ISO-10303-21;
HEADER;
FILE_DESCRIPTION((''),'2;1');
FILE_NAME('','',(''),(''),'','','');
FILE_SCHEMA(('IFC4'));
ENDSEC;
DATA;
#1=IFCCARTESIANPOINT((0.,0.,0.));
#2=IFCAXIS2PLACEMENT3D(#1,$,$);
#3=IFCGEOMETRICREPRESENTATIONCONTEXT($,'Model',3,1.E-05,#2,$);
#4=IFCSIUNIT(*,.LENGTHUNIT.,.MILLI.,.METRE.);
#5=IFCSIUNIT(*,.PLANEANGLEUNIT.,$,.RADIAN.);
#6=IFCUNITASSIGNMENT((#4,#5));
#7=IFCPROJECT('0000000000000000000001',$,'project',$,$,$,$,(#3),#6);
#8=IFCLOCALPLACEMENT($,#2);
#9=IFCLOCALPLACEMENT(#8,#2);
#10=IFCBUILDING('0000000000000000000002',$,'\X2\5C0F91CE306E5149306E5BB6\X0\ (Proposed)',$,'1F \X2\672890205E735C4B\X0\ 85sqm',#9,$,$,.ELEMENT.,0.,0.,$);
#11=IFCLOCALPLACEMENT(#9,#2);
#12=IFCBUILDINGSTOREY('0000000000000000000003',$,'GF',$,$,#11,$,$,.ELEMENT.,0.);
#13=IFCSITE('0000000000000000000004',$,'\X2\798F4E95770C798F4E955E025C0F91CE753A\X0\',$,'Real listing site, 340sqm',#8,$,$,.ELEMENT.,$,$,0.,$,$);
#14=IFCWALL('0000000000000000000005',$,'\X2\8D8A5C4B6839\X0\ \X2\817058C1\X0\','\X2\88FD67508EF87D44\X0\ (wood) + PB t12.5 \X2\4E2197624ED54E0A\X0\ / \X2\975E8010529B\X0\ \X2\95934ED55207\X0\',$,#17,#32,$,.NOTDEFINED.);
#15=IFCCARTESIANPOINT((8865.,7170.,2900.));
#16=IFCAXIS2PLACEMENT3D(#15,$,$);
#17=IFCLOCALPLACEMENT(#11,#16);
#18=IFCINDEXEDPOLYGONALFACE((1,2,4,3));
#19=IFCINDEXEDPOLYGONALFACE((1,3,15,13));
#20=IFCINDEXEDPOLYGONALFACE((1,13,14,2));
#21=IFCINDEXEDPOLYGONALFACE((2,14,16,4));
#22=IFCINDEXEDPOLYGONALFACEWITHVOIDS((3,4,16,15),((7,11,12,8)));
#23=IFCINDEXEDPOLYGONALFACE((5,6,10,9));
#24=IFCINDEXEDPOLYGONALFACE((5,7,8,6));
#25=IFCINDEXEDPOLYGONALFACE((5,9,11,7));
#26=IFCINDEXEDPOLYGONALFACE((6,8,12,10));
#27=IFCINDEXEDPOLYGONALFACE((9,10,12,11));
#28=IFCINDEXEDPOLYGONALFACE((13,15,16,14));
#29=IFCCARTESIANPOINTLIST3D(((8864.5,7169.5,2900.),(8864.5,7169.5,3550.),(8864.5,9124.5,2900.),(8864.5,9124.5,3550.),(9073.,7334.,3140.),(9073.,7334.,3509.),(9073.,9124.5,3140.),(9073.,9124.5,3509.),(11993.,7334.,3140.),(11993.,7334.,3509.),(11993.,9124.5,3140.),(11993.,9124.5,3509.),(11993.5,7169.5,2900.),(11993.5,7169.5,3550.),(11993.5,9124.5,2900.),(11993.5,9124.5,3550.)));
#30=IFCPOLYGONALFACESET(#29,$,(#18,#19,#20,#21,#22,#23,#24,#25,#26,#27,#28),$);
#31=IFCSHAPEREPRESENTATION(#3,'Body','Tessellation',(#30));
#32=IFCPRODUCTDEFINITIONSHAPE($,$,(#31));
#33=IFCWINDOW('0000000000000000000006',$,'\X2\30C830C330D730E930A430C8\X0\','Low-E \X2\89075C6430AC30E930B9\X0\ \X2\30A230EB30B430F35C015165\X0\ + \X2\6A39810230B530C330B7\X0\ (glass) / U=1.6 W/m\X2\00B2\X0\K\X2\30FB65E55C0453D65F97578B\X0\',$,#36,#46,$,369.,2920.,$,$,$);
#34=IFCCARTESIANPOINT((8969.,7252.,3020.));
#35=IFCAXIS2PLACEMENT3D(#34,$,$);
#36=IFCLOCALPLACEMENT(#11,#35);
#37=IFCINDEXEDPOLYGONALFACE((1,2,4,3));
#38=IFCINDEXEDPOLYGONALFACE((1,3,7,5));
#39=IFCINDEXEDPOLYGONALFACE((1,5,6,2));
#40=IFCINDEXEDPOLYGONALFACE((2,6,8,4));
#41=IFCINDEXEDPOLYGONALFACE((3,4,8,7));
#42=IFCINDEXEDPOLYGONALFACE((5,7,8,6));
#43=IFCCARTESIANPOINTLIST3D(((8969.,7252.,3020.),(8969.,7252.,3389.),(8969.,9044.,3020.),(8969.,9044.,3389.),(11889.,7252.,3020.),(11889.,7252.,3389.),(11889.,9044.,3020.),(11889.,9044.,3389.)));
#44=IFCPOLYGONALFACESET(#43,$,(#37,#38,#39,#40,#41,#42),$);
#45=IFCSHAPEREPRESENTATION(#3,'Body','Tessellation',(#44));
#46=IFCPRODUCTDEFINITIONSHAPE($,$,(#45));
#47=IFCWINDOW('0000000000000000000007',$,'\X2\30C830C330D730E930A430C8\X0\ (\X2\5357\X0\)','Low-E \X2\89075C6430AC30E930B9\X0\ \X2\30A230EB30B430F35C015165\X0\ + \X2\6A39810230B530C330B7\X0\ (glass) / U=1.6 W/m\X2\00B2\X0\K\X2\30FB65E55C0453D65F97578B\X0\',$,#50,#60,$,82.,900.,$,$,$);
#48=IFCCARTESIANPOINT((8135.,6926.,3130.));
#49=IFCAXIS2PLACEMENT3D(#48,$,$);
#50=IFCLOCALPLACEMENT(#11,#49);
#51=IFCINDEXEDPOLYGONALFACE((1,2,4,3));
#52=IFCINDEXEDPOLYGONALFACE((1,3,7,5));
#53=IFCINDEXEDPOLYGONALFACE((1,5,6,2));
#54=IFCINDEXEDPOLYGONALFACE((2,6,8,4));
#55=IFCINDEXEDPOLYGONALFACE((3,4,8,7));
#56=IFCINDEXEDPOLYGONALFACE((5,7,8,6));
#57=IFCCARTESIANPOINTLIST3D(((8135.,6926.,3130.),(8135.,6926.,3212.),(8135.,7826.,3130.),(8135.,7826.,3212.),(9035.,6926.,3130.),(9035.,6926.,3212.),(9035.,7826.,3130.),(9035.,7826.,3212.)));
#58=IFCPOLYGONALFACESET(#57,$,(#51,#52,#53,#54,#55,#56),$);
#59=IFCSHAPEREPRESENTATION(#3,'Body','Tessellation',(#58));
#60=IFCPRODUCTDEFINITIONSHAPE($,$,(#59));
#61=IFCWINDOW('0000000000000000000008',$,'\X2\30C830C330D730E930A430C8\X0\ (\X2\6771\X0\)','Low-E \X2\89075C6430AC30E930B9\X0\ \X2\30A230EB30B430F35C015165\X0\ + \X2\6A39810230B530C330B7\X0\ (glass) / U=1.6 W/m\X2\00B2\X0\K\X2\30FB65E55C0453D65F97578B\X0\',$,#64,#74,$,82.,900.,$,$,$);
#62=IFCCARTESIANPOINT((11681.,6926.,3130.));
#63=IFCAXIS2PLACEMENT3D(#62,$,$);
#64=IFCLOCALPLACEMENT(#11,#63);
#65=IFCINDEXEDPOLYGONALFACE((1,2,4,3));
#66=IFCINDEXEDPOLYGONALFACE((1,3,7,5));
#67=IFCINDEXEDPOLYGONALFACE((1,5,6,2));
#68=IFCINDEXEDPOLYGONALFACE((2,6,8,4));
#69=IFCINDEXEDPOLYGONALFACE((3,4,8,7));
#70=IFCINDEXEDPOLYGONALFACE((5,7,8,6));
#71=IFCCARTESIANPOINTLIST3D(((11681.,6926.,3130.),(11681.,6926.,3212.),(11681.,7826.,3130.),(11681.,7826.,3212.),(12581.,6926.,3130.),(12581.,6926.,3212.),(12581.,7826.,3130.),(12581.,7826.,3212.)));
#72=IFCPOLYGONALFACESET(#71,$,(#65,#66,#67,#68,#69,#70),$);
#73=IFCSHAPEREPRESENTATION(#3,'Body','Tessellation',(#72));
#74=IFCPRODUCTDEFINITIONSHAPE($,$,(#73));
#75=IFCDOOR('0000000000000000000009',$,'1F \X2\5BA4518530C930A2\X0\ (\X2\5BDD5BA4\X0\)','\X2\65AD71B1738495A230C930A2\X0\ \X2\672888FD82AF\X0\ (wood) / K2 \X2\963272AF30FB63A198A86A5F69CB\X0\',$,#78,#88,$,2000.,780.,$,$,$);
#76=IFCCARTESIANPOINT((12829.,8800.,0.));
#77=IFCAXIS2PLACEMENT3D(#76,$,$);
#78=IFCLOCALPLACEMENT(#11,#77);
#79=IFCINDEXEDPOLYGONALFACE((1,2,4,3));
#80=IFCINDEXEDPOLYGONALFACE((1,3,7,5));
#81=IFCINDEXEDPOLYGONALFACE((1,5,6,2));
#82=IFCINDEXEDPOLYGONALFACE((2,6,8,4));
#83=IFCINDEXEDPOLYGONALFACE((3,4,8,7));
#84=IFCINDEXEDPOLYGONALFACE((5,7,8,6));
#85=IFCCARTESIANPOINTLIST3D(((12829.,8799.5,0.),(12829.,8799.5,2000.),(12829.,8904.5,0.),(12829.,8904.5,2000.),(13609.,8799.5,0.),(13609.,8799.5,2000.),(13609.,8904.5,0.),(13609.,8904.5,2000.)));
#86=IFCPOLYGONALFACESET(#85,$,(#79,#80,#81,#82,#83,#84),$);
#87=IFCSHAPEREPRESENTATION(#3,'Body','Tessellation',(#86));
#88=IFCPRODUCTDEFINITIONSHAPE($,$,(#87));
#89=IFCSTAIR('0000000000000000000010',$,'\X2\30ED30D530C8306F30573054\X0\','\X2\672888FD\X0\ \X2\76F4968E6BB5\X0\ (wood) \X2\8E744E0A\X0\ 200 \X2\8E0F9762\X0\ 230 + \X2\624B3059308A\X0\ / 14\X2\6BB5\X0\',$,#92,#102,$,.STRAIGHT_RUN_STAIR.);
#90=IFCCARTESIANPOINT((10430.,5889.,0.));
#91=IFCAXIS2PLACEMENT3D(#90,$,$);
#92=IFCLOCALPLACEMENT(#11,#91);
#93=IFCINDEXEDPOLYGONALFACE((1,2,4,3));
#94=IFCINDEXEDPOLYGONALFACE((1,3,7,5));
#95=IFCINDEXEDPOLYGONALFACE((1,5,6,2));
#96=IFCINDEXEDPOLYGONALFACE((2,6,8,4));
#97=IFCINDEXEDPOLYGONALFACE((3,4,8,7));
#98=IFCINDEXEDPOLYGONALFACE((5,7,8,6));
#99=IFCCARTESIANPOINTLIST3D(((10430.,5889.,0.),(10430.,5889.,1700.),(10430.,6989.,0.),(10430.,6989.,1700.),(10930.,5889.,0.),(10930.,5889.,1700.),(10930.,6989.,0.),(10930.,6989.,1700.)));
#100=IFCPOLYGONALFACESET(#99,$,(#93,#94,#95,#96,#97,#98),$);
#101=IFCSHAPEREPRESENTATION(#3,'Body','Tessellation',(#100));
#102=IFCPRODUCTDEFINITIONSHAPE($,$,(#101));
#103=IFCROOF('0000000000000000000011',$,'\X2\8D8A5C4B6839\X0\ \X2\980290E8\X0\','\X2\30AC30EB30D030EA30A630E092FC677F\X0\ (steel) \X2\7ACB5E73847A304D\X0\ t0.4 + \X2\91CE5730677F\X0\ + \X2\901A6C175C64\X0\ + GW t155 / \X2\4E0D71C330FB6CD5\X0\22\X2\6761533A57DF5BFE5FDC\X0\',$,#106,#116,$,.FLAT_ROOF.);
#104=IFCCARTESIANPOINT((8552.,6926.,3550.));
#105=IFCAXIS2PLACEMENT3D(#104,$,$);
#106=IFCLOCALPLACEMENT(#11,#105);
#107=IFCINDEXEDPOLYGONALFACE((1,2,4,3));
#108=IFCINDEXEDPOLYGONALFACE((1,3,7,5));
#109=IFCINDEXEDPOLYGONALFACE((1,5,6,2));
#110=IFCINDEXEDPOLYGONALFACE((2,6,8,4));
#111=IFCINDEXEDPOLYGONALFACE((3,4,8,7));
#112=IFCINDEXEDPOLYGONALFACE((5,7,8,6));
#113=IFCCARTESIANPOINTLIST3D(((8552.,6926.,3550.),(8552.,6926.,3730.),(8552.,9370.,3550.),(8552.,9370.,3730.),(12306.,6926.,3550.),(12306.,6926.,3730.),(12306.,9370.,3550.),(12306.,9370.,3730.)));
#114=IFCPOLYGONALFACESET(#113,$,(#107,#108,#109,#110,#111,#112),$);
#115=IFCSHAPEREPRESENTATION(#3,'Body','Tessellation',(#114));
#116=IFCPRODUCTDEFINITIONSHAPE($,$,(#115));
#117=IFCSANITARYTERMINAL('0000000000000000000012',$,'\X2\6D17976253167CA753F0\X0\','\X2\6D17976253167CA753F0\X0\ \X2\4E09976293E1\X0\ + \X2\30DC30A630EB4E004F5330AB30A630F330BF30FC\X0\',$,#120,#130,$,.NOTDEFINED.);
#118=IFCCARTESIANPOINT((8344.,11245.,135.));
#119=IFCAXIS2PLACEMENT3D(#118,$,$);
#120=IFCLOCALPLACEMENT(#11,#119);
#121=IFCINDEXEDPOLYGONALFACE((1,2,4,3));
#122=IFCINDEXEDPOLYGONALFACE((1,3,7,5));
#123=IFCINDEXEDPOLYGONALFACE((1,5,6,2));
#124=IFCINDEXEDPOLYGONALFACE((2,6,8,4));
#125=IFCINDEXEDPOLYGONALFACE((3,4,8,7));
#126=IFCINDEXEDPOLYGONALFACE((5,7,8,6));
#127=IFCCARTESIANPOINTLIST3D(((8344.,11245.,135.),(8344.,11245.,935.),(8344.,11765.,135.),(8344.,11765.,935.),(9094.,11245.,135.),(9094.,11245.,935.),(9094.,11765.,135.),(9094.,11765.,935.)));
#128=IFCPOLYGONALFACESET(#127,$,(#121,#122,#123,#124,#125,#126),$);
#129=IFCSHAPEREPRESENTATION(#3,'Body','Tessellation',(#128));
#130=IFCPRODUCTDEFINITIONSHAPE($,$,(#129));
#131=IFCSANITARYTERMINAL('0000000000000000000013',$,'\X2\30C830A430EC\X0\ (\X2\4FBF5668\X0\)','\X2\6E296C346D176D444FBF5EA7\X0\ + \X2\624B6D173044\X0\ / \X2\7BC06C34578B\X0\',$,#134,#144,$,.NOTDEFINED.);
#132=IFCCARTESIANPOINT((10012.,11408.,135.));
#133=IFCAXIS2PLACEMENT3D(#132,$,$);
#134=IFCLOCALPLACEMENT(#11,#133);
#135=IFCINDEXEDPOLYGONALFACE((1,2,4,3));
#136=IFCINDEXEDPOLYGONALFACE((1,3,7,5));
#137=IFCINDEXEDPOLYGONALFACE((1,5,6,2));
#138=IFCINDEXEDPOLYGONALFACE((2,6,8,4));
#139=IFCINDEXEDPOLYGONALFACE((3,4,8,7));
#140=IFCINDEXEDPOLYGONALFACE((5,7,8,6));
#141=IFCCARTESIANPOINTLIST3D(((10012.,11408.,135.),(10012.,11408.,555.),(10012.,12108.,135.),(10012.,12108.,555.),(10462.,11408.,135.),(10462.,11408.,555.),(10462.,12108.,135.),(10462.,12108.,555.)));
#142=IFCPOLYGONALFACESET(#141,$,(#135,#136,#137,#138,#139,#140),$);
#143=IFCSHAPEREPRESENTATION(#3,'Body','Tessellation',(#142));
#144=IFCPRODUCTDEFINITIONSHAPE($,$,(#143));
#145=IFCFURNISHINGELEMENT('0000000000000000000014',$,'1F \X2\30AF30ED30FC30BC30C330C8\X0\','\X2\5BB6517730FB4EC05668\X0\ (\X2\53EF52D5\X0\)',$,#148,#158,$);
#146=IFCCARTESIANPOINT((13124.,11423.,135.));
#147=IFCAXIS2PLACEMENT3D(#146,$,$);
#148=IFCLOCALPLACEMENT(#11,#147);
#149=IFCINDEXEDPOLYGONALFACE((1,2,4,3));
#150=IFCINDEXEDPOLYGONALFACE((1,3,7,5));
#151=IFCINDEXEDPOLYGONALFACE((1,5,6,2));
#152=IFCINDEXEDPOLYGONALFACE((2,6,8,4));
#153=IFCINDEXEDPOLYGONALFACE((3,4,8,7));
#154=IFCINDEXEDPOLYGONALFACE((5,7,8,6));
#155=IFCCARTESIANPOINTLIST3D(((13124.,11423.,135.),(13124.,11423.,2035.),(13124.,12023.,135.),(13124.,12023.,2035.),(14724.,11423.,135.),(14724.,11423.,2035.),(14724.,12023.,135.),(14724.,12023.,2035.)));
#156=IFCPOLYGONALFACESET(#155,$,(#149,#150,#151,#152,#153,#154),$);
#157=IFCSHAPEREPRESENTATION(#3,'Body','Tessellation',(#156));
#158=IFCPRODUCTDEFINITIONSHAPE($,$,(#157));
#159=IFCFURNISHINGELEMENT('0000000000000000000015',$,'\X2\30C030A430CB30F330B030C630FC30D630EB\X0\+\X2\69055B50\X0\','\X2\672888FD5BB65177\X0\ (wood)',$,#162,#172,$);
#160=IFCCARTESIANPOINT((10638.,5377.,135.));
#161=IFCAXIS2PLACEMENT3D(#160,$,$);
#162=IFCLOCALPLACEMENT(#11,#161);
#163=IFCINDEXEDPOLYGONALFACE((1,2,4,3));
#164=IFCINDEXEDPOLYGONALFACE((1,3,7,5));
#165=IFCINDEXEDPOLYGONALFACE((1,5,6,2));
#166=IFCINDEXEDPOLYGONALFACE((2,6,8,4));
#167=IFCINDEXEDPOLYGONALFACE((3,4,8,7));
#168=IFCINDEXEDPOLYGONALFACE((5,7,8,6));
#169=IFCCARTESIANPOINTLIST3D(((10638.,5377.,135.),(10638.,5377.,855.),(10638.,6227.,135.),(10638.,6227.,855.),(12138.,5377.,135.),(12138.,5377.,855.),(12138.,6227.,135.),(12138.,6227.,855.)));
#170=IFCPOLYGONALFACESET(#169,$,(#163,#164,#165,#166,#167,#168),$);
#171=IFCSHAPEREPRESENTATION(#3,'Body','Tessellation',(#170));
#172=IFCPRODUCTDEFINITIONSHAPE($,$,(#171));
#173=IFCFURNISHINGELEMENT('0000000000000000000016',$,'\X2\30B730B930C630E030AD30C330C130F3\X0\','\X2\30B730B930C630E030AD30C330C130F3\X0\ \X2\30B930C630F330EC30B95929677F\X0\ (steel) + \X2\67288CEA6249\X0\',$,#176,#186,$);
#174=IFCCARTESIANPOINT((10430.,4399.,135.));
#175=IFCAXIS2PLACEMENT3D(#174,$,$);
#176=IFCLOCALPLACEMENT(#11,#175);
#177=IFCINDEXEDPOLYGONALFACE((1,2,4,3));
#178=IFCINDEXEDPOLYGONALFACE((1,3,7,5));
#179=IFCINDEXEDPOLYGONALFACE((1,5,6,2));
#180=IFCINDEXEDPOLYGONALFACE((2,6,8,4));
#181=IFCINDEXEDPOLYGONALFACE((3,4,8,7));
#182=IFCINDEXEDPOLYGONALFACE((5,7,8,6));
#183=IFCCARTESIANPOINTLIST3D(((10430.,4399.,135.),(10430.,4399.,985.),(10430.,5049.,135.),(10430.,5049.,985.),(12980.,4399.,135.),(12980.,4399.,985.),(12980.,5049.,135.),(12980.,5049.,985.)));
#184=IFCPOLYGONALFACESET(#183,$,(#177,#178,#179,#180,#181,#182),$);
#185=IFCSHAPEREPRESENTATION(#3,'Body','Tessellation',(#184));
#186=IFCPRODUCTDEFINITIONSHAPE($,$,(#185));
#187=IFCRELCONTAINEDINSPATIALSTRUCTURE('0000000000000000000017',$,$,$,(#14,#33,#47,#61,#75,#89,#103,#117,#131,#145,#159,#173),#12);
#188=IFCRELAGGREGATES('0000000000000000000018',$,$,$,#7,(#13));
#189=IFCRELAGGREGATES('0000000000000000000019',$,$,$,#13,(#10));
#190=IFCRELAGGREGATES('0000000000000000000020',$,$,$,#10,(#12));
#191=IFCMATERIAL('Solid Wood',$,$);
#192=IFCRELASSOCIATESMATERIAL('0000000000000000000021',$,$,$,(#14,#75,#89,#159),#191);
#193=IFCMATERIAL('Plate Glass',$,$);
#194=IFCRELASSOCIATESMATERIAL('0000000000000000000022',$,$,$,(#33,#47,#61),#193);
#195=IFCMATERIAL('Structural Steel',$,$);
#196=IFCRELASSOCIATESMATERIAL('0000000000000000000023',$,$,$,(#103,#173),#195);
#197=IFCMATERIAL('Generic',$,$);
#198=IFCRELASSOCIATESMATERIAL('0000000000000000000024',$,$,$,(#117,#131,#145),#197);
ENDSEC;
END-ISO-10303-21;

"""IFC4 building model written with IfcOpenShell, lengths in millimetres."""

from ifc_helpers import new_model, si_unit, frame, frame_2d, origin, place, context, project, spatial, rectangle, extrude, material, element, fill, save


model = new_model("IFC4")

# Units and contexts
model_context = context("Model", 3, precision=1e-05, world=origin())
ifc_project = project(units=[si_unit("LENGTHUNIT", "METRE", prefix="MILLI"), si_unit("PLANEANGLEUNIT", "RADIAN")], contexts=[model_context])

# Site, building, storey
site_placement = place(None, origin())
site = spatial("IfcSite", under=ifc_project, at=site_placement, Name="福井県福井市小野町", ObjectType="Real listing site, 340sqm", CompositionType="ELEMENT", RefElevation=0.0)
building_placement = place(site_placement, origin())
building = spatial("IfcBuilding", under=site, at=building_placement, Name="小野の光の家 (Proposed)", ObjectType="1F 木造平屋 85sqm", CompositionType="ELEMENT", ElevationOfRefHeight=0.0, ElevationOfTerrain=0.0)
storey_placement = place(building_placement, origin())
storey = spatial("IfcBuildingStorey", under=building, at=storey_placement, Name="GF", CompositionType="ELEMENT", Elevation=0.0)

# Shared definitions
ifc_material_1 = material(Name="Solid Wood")
ifc_material_2 = material(Name="Plate Glass")

# Wall, openings, windows
wall_1_placement = place(storey_placement, frame((8865.0, 7170.0, 2900.0)))
wall_1 = element("IfcWall", 1, at=wall_1_placement, inside=storey, material=ifc_material_1, Name="越屋根 腰壁", Description="製材軸組 (wood) + PB t12.5 両面仕上 / 非耐力 間仕切", PredefinedType="NOTDEFINED", context=model_context, shape_type="SweptSolid", body=[
    extrude(rectangle(XDim=3129.0, YDim=1955.0, at=frame_2d((1564.0, 977.0))), frame((8865.0, 7170.0, 2900.0)), (0.0, 0.0, 1.0), 650.0),
])
opening_1_placement = place(storey_placement, frame((8969.0, 7252.0, 3020.0)))
opening_1 = element("IfcOpeningElement", 2, at=opening_1_placement, cuts=wall_1, PredefinedType="NOTDEFINED", context=model_context, shape_type="SweptSolid", body=[
    extrude(rectangle(XDim=2920.0, YDim=1792.0, at=frame_2d((1460.0, 896.0))), frame((8969.0, 7252.0, 3020.0)), (0.0, 0.0, 1.0), 369.0),
])
opening_2_placement = place(storey_placement, frame((8135.0, 6926.0, 3130.0)))
opening_2 = element("IfcOpeningElement", 3, at=opening_2_placement, cuts=wall_1, PredefinedType="NOTDEFINED", context=model_context, shape_type="SweptSolid", body=[
    extrude(rectangle(XDim=900.0, YDim=900.0, at=frame_2d((450.0, 450.0))), frame((8135.0, 6926.0, 3130.0)), (0.0, 0.0, 1.0), 82.0),
])
opening_3_placement = place(storey_placement, frame((11681.0, 6926.0, 3130.0)))
opening_3 = element("IfcOpeningElement", 4, at=opening_3_placement, cuts=wall_1, PredefinedType="NOTDEFINED", context=model_context, shape_type="SweptSolid", body=[
    extrude(rectangle(XDim=900.0, YDim=900.0, at=frame_2d((450.0, 450.0))), frame((11681.0, 6926.0, 3130.0)), (0.0, 0.0, 1.0), 82.0),
])
window_1_placement = place(storey_placement, frame((8969.0, 7252.0, 3020.0)))
window_1 = element("IfcWindow", 5, at=window_1_placement, inside=storey, material=ifc_material_2, Name="トップライト", Description="Low-E 複層ガラス アルゴン封入 + 樹脂サッシ (glass) / U=1.6 W/m²K・日射取得型", OverallHeight=369.0, OverallWidth=2920.0, context=model_context, shape_type="SweptSolid", body=[
    extrude(rectangle(XDim=2920.0, YDim=1792.0, at=frame_2d((1460.0, 896.0))), frame((8969.0, 7252.0, 3020.0)), (0.0, 0.0, 1.0), 369.0),
])
fill(opening_1, window_1)
window_2_placement = place(storey_placement, frame((8135.0, 6926.0, 3130.0)))
window_2 = element("IfcWindow", 6, at=window_2_placement, inside=storey, material=ifc_material_2, Name="トップライト (南)", Description="Low-E 複層ガラス アルゴン封入 + 樹脂サッシ (glass) / U=1.6 W/m²K・日射取得型", OverallHeight=82.0, OverallWidth=900.0, context=model_context, shape_type="SweptSolid", body=[
    extrude(rectangle(XDim=900.0, YDim=900.0, at=frame_2d((450.0, 450.0))), frame((8135.0, 6926.0, 3130.0)), (0.0, 0.0, 1.0), 82.0),
])
fill(opening_2, window_2)
window_3_placement = place(storey_placement, frame((11681.0, 6926.0, 3130.0)))
window_3 = element("IfcWindow", 7, at=window_3_placement, inside=storey, material=ifc_material_2, Name="トップライト (東)", Description="Low-E 複層ガラス アルゴン封入 + 樹脂サッシ (glass) / U=1.6 W/m²K・日射取得型", OverallHeight=82.0, OverallWidth=900.0, context=model_context, shape_type="SweptSolid", body=[
    extrude(rectangle(XDim=900.0, YDim=900.0, at=frame_2d((450.0, 450.0))), frame((11681.0, 6926.0, 3130.0)), (0.0, 0.0, 1.0), 82.0),
])
fill(opening_3, window_3)

# Door
door_placement = place(storey_placement, frame((12829.0, 8800.0, 0.0)))
element("IfcDoor", 8, at=door_placement, inside=storey, material=ifc_material_1, Name="1F 室内ドア (寝室)", Description="断熱玄関ドア 木製芯 (wood) / K2 防犯・採風機構", OverallHeight=2000.0, OverallWidth=780.0, context=model_context, shape_type="SweptSolid", body=[
    extrude(rectangle(XDim=780.0, YDim=105.0, at=frame_2d((390.0, 52.0))), frame((12829.0, 8800.0, 0.0)), (0.0, 0.0, 1.0), 2000.0),
])

# Stair
stair_placement = place(storey_placement, frame((10430.0, 5889.0, 0.0)))
element("IfcStair", 9, at=stair_placement, inside=storey, material=ifc_material_1, Name="ロフトはしご", Description="木製 直階段 (wood) 蹴上 200 踏面 230 + 手すり / 14段", PredefinedType="STRAIGHT_RUN_STAIR", context=model_context, shape_type="SweptSolid", body=[
    extrude(rectangle(XDim=500.0, YDim=1100.0, at=frame_2d((250.0, 550.0))), frame((10430.0, 5889.0, 0.0)), (0.0, 0.0, 1.0), 1700.0),
])

# Roof
ifc_material_3 = material(Name="Structural Steel")
roof_placement = place(storey_placement, frame((8552.0, 6926.0, 3550.0)))
element("IfcRoof", 10, at=roof_placement, inside=storey, material=ifc_material_3, Name="越屋根 頂部", Description="ガルバリウム鋼板 (steel) 立平葺き t0.4 + 野地板 + 通気層 + GW t155 / 不燃・法22条区域対応", PredefinedType="FLAT_ROOF", context=model_context, shape_type="SweptSolid", body=[
    extrude(rectangle(XDim=3754.0, YDim=2444.0, at=frame_2d((1877.0, 1222.0))), frame((8552.0, 6926.0, 3550.0)), (0.0, 0.0, 1.0), 180.0),
])

# Sanitary terminals
ifc_material_4 = material(Name="Generic")
sanitary_terminal_1_placement = place(storey_placement, frame((8344.0, 11245.0, 135.0)))
element("IfcSanitaryTerminal", 11, at=sanitary_terminal_1_placement, inside=storey, material=ifc_material_4, Name="洗面化粧台", Description="洗面化粧台 三面鏡 + ボウル一体カウンター", PredefinedType="NOTDEFINED", context=model_context, shape_type="SweptSolid", body=[
    extrude(rectangle(XDim=750.0, YDim=520.0, at=frame_2d((375.0, 260.0))), frame((8344.0, 11245.0, 135.0)), (0.0, 0.0, 1.0), 800.0),
])
sanitary_terminal_2_placement = place(storey_placement, frame((10012.0, 11408.0, 135.0)))
element("IfcSanitaryTerminal", 12, at=sanitary_terminal_2_placement, inside=storey, material=ifc_material_4, Name="トイレ (便器)", Description="温水洗浄便座 + 手洗い / 節水型", PredefinedType="NOTDEFINED", context=model_context, shape_type="SweptSolid", body=[
    extrude(rectangle(XDim=450.0, YDim=700.0, at=frame_2d((225.0, 350.0))), frame((10012.0, 11408.0, 135.0)), (0.0, 0.0, 1.0), 420.0),
])

# Furnishing elements
furnishing_1_placement = place(storey_placement, frame((13124.0, 11423.0, 135.0)))
element("IfcFurnishingElement", 13, at=furnishing_1_placement, inside=storey, material=ifc_material_4, Name="1F クローゼット", Description="家具・什器 (可動)", context=model_context, shape_type="SweptSolid", body=[
    extrude(rectangle(XDim=1600.0, YDim=600.0, at=frame_2d((800.0, 300.0))), frame((13124.0, 11423.0, 135.0)), (0.0, 0.0, 1.0), 1900.0),
])
furnishing_2_placement = place(storey_placement, frame((10638.0, 5377.0, 135.0)))
element("IfcFurnishingElement", 14, at=furnishing_2_placement, inside=storey, material=ifc_material_1, Name="ダイニングテーブル+椅子", Description="木製家具 (wood)", context=model_context, shape_type="SweptSolid", body=[
    extrude(rectangle(XDim=1500.0, YDim=850.0, at=frame_2d((750.0, 425.0))), frame((10638.0, 5377.0, 135.0)), (0.0, 0.0, 1.0), 720.0),
])
furnishing_3_placement = place(storey_placement, frame((10430.0, 4399.0, 135.0)))
element("IfcFurnishingElement", 15, at=furnishing_3_placement, inside=storey, material=ifc_material_3, Name="システムキッチン", Description="システムキッチン ステンレス天板 (steel) + 木質扉", context=model_context, shape_type="SweptSolid", body=[
    extrude(rectangle(XDim=2550.0, YDim=650.0, at=frame_2d((1275.0, 325.0))), frame((10430.0, 4399.0, 135.0)), (0.0, 0.0, 1.0), 850.0),
])

save(model, "model.ifc")
